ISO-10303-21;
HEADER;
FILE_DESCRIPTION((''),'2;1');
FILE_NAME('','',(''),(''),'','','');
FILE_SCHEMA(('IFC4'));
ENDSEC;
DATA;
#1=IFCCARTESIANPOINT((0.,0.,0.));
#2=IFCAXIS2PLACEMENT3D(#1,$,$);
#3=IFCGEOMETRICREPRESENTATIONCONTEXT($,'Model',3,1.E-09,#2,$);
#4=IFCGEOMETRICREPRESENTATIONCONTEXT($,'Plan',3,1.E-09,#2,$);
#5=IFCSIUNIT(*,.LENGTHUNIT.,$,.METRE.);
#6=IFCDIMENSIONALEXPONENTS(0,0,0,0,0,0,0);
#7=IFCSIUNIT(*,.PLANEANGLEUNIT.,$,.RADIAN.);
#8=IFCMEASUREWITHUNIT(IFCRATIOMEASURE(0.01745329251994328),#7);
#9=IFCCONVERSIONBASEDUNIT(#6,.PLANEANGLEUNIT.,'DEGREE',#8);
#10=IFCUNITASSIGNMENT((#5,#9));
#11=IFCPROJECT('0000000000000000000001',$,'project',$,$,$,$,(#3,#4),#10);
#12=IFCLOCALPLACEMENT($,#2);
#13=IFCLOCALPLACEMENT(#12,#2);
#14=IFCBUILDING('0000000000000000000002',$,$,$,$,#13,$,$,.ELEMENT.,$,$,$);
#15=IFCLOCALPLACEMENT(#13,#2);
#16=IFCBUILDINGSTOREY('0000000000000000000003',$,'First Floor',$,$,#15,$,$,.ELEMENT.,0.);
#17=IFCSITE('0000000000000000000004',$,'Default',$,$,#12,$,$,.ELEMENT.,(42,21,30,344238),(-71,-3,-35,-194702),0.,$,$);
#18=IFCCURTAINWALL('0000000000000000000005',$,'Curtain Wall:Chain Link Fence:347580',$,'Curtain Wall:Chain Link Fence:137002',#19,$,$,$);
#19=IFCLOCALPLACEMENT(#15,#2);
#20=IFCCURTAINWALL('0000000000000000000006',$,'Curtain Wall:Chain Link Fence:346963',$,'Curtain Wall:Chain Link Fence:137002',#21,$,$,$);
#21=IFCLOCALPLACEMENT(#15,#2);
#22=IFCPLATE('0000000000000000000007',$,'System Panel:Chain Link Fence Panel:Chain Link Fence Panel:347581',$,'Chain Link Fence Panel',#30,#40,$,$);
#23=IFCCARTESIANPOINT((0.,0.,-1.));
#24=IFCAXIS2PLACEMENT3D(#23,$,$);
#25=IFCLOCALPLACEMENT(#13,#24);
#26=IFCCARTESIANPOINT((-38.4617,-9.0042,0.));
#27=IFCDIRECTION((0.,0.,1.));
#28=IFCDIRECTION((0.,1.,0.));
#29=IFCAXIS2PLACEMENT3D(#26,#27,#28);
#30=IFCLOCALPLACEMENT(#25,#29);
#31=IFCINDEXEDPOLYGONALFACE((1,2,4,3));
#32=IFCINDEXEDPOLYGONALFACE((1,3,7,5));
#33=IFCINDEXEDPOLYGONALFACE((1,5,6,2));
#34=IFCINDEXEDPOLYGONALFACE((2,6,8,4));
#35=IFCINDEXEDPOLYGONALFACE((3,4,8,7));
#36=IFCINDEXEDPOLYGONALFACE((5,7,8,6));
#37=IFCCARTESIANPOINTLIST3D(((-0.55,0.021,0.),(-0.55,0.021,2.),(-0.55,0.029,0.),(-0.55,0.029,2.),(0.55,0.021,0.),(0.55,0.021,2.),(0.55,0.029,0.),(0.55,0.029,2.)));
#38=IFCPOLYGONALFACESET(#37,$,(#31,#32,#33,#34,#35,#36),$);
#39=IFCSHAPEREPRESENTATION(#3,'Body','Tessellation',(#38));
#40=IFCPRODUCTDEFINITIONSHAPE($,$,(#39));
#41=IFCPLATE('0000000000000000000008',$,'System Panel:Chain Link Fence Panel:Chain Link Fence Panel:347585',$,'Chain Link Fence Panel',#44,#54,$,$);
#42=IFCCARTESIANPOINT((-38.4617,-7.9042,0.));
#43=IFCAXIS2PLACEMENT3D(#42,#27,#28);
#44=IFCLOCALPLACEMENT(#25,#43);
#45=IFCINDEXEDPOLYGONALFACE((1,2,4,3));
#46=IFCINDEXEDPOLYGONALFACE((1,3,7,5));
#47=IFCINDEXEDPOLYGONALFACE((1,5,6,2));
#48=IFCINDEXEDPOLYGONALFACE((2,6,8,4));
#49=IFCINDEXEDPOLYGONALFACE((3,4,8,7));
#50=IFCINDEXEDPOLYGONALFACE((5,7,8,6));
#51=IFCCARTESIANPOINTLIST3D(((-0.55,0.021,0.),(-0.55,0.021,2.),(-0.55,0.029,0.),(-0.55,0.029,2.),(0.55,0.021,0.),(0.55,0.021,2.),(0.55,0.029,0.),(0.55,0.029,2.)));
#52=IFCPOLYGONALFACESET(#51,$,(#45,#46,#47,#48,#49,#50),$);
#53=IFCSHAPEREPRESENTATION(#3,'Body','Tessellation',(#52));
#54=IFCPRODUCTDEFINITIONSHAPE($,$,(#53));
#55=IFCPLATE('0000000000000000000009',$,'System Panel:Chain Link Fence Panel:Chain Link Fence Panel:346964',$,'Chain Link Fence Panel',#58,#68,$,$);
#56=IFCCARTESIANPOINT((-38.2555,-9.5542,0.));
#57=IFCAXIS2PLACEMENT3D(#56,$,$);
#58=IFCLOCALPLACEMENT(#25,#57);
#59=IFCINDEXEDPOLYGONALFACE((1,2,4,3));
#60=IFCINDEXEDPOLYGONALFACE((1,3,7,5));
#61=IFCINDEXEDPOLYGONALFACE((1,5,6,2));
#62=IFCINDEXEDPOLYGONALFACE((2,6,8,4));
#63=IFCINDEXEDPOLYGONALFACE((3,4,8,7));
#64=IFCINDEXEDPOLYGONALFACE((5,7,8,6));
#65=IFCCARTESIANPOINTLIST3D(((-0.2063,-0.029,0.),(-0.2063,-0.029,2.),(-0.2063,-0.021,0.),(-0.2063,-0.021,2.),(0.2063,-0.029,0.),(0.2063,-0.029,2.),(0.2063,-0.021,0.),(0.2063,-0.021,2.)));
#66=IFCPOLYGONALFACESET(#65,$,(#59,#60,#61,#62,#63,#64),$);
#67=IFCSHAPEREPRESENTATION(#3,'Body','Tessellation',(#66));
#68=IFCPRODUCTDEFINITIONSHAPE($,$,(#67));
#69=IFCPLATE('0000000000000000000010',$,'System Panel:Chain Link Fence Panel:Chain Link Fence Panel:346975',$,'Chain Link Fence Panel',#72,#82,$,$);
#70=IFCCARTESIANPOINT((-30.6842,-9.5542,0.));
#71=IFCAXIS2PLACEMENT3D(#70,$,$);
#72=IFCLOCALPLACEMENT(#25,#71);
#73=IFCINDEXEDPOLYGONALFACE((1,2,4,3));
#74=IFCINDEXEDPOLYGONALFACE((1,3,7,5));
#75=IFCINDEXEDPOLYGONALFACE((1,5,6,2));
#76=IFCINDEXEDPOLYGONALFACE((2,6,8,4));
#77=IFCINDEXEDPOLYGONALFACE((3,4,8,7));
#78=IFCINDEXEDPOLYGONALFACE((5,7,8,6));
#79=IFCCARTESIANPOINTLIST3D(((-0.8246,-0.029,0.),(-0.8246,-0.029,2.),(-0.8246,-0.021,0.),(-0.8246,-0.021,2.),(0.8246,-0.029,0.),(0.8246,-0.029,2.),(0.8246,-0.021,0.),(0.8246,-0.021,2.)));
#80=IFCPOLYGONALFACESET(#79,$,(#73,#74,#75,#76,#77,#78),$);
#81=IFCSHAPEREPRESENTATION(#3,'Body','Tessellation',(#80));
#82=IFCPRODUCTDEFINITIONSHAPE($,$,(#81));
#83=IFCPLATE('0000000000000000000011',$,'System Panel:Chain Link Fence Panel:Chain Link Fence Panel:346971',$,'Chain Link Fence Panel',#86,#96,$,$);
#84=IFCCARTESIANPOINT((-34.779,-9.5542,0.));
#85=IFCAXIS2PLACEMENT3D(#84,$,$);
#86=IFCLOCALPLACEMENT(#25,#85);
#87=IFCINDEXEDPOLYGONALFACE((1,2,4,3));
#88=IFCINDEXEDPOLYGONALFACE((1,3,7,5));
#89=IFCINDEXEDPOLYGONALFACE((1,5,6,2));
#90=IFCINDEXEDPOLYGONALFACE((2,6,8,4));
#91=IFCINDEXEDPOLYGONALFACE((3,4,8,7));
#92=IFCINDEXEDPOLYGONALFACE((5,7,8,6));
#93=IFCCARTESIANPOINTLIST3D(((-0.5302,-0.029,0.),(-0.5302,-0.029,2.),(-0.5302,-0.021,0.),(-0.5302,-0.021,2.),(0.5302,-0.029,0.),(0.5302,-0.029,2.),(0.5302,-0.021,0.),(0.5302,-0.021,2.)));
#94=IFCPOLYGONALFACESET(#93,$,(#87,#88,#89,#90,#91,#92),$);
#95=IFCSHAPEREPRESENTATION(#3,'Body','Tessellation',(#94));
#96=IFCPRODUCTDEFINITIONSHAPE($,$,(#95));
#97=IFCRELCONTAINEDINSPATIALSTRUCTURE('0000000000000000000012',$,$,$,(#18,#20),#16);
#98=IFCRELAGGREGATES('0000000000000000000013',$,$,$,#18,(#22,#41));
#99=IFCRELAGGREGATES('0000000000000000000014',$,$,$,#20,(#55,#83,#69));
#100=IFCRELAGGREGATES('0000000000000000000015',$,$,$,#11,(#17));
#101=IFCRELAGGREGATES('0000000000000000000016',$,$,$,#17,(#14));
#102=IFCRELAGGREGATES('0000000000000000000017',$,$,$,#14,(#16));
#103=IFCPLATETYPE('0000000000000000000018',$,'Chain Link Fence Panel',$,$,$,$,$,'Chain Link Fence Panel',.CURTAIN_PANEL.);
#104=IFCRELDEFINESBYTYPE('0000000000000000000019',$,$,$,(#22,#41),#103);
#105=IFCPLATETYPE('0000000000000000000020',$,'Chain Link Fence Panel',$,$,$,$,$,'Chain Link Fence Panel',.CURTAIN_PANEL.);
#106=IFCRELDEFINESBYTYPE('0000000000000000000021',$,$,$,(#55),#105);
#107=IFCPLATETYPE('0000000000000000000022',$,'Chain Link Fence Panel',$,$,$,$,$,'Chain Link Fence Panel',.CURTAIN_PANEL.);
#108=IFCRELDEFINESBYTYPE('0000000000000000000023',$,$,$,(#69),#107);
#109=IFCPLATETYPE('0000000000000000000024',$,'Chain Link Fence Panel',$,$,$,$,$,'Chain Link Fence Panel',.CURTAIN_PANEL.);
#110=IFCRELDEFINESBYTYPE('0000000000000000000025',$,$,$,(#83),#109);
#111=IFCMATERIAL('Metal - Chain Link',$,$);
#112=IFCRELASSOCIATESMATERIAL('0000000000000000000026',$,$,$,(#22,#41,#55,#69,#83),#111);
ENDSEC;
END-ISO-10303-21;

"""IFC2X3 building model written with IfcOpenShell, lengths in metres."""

from ifc_helpers import new_model, entity, si_unit, converted_unit, frame, origin, origin_2d_with_axis, place, context, project, spatial, rectangle, extrude, source, transform, mapped, material, type_object, type_shapes, element, aggregate, save


model = new_model("IFC2X3")

# Units and contexts
model_context = context("Model", 3, precision=1e-09, world=origin())
plan_context = context("Plan", 3, precision=1e-09, world=origin())
ifc_project = project(units=[si_unit("LENGTHUNIT", "METRE"), converted_unit("PLANEANGLEUNIT", "DEGREE", entity("IfcRatioMeasure", 0.01745329251994328), si_unit("PLANEANGLEUNIT", "RADIAN"), dimensions=[0, 0, 0, 0, 0, 0, 0])], contexts=[model_context, plan_context])

# Site, building, storey
site_placement = place(None, origin())
site = spatial("IfcSite", under=ifc_project, at=site_placement, Name="Default", CompositionType="ELEMENT", RefLatitude=(42, 21, 30, 344238), RefLongitude=(-71, -3, -35, -194702), RefElevation=0.0)
building_placement = place(site_placement, origin())
building = spatial("IfcBuilding", under=site, at=building_placement, CompositionType="ELEMENT")
storey_placement = place(building_placement, origin())
storey = spatial("IfcBuildingStorey", under=building, at=storey_placement, Name="First Floor", CompositionType="ELEMENT", Elevation=0.0)

# Curtain walls
curtain_wall_1_placement = place(storey_placement, origin())
curtain_wall_1 = element("IfcCurtainWall", 1, at=curtain_wall_1_placement, inside=storey, Name="Curtain Wall:Chain Link Fence:347580", ObjectType="Curtain Wall:Chain Link Fence:137002")
placement = place(building_placement, frame((0.0, 0.0, -1.0)))
curtain_wall_2_placement = place(storey_placement, origin())
curtain_wall_2 = element("IfcCurtainWall", 2, at=curtain_wall_2_placement, inside=storey, Name="Curtain Wall:Chain Link Fence:346963", ObjectType="Curtain Wall:Chain Link Fence:137002")

# Plates
ifc_material_1 = material(Name="Metal - Chain Link")
plate_type_1 = type_object("IfcPlateType", Name="Chain Link Fence Panel", ElementType="Chain Link Fence Panel", PredefinedType="CURTAIN_PANEL")
shared_shape_1 = source(origin(), model_context, "Body", "SweptSolid", [
    extrude(rectangle(XDim=0.008, YDim=1.1, at=origin_2d_with_axis()), frame((0.0, 0.025, 0.0), z_axis=(0.0, 0.0, 1.0), x_axis=(0.0, 1.0, 0.0)), (0.0, 0.0, 1.0), 2.0),
])
type_shapes(plate_type_1, [shared_shape_1])
plate_1_placement = place(placement, frame((-38.4617, -9.0042, 0.0), z_axis=(0.0, 0.0, 1.0), x_axis=(0.0, 1.0, 0.0)))
plate_1 = element("IfcPlate", 3, at=plate_1_placement, type_object=plate_type_1, material=ifc_material_1, Name="System Panel:Chain Link Fence Panel:Chain Link Fence Panel:347581", ObjectType="Chain Link Fence Panel", context=model_context, shape_type="MappedRepresentation", body=[
    mapped(shared_shape_1, transform((0.0, 0.0, 0.0), scale=1.0)),
])
plate_2_placement = place(placement, frame((-38.4617, -7.9042, 0.0), z_axis=(0.0, 0.0, 1.0), x_axis=(0.0, 1.0, 0.0)))
plate_2 = element("IfcPlate", 4, at=plate_2_placement, type_object=plate_type_1, material=ifc_material_1, Name="System Panel:Chain Link Fence Panel:Chain Link Fence Panel:347585", ObjectType="Chain Link Fence Panel", context=model_context, shape_type="MappedRepresentation", body=[
    mapped(shared_shape_1, transform((0.0, 0.0, 0.0), scale=1.0)),
])
aggregate(curtain_wall_1, [plate_1, plate_2])
plate_type_2 = type_object("IfcPlateType", Name="Chain Link Fence Panel", ElementType="Chain Link Fence Panel", PredefinedType="CURTAIN_PANEL")
shared_shape_2 = source(origin(), model_context, "Body", "SweptSolid", [
    extrude(rectangle(XDim=0.008, YDim=0.4126, at=origin_2d_with_axis()), frame((0.0, -0.025, 0.0), z_axis=(0.0, 0.0, 1.0), x_axis=(0.0, 1.0, 0.0)), (0.0, 0.0, 1.0), 2.0),
])
type_shapes(plate_type_2, [shared_shape_2])
plate_3_placement = place(placement, frame((-38.2555, -9.5542, 0.0)))
plate_3 = element("IfcPlate", 5, at=plate_3_placement, type_object=plate_type_2, material=ifc_material_1, Name="System Panel:Chain Link Fence Panel:Chain Link Fence Panel:346964", ObjectType="Chain Link Fence Panel", context=model_context, shape_type="MappedRepresentation", body=[
    mapped(shared_shape_2, transform((0.0, 0.0, 0.0), scale=1.0)),
])
plate_type_3 = type_object("IfcPlateType", Name="Chain Link Fence Panel", ElementType="Chain Link Fence Panel", PredefinedType="CURTAIN_PANEL")
shared_shape_3 = source(origin(), model_context, "Body", "SweptSolid", [
    extrude(rectangle(XDim=0.008, YDim=1.6491, at=origin_2d_with_axis()), frame((0.0, -0.025, 0.0), z_axis=(0.0, 0.0, 1.0), x_axis=(0.0, 1.0, 0.0)), (0.0, 0.0, 1.0), 2.0),
])
type_shapes(plate_type_3, [shared_shape_3])
plate_4_placement = place(placement, frame((-30.6842, -9.5542, 0.0)))
plate_4 = element("IfcPlate", 6, at=plate_4_placement, type_object=plate_type_3, material=ifc_material_1, Name="System Panel:Chain Link Fence Panel:Chain Link Fence Panel:346975", ObjectType="Chain Link Fence Panel", context=model_context, shape_type="MappedRepresentation", body=[
    mapped(shared_shape_3, transform((0.0, 0.0, 0.0), scale=1.0)),
])
plate_type_4 = type_object("IfcPlateType", Name="Chain Link Fence Panel", ElementType="Chain Link Fence Panel", PredefinedType="CURTAIN_PANEL")
shared_shape_4 = source(origin(), model_context, "Body", "SweptSolid", [
    extrude(rectangle(XDim=0.008, YDim=1.0604, at=origin_2d_with_axis()), frame((0.0, -0.025, 0.0), z_axis=(0.0, 0.0, 1.0), x_axis=(0.0, 1.0, 0.0)), (0.0, 0.0, 1.0), 2.0),
])
type_shapes(plate_type_4, [shared_shape_4])
plate_5_placement = place(placement, frame((-34.779, -9.5542, 0.0)))
plate_5 = element("IfcPlate", 7, at=plate_5_placement, type_object=plate_type_4, material=ifc_material_1, Name="System Panel:Chain Link Fence Panel:Chain Link Fence Panel:346971", ObjectType="Chain Link Fence Panel", context=model_context, shape_type="MappedRepresentation", body=[
    mapped(shared_shape_4, transform((0.0, 0.0, 0.0), scale=1.0)),
])
aggregate(curtain_wall_2, [plate_3, plate_5, plate_4])

save(model, "model.ifc")
